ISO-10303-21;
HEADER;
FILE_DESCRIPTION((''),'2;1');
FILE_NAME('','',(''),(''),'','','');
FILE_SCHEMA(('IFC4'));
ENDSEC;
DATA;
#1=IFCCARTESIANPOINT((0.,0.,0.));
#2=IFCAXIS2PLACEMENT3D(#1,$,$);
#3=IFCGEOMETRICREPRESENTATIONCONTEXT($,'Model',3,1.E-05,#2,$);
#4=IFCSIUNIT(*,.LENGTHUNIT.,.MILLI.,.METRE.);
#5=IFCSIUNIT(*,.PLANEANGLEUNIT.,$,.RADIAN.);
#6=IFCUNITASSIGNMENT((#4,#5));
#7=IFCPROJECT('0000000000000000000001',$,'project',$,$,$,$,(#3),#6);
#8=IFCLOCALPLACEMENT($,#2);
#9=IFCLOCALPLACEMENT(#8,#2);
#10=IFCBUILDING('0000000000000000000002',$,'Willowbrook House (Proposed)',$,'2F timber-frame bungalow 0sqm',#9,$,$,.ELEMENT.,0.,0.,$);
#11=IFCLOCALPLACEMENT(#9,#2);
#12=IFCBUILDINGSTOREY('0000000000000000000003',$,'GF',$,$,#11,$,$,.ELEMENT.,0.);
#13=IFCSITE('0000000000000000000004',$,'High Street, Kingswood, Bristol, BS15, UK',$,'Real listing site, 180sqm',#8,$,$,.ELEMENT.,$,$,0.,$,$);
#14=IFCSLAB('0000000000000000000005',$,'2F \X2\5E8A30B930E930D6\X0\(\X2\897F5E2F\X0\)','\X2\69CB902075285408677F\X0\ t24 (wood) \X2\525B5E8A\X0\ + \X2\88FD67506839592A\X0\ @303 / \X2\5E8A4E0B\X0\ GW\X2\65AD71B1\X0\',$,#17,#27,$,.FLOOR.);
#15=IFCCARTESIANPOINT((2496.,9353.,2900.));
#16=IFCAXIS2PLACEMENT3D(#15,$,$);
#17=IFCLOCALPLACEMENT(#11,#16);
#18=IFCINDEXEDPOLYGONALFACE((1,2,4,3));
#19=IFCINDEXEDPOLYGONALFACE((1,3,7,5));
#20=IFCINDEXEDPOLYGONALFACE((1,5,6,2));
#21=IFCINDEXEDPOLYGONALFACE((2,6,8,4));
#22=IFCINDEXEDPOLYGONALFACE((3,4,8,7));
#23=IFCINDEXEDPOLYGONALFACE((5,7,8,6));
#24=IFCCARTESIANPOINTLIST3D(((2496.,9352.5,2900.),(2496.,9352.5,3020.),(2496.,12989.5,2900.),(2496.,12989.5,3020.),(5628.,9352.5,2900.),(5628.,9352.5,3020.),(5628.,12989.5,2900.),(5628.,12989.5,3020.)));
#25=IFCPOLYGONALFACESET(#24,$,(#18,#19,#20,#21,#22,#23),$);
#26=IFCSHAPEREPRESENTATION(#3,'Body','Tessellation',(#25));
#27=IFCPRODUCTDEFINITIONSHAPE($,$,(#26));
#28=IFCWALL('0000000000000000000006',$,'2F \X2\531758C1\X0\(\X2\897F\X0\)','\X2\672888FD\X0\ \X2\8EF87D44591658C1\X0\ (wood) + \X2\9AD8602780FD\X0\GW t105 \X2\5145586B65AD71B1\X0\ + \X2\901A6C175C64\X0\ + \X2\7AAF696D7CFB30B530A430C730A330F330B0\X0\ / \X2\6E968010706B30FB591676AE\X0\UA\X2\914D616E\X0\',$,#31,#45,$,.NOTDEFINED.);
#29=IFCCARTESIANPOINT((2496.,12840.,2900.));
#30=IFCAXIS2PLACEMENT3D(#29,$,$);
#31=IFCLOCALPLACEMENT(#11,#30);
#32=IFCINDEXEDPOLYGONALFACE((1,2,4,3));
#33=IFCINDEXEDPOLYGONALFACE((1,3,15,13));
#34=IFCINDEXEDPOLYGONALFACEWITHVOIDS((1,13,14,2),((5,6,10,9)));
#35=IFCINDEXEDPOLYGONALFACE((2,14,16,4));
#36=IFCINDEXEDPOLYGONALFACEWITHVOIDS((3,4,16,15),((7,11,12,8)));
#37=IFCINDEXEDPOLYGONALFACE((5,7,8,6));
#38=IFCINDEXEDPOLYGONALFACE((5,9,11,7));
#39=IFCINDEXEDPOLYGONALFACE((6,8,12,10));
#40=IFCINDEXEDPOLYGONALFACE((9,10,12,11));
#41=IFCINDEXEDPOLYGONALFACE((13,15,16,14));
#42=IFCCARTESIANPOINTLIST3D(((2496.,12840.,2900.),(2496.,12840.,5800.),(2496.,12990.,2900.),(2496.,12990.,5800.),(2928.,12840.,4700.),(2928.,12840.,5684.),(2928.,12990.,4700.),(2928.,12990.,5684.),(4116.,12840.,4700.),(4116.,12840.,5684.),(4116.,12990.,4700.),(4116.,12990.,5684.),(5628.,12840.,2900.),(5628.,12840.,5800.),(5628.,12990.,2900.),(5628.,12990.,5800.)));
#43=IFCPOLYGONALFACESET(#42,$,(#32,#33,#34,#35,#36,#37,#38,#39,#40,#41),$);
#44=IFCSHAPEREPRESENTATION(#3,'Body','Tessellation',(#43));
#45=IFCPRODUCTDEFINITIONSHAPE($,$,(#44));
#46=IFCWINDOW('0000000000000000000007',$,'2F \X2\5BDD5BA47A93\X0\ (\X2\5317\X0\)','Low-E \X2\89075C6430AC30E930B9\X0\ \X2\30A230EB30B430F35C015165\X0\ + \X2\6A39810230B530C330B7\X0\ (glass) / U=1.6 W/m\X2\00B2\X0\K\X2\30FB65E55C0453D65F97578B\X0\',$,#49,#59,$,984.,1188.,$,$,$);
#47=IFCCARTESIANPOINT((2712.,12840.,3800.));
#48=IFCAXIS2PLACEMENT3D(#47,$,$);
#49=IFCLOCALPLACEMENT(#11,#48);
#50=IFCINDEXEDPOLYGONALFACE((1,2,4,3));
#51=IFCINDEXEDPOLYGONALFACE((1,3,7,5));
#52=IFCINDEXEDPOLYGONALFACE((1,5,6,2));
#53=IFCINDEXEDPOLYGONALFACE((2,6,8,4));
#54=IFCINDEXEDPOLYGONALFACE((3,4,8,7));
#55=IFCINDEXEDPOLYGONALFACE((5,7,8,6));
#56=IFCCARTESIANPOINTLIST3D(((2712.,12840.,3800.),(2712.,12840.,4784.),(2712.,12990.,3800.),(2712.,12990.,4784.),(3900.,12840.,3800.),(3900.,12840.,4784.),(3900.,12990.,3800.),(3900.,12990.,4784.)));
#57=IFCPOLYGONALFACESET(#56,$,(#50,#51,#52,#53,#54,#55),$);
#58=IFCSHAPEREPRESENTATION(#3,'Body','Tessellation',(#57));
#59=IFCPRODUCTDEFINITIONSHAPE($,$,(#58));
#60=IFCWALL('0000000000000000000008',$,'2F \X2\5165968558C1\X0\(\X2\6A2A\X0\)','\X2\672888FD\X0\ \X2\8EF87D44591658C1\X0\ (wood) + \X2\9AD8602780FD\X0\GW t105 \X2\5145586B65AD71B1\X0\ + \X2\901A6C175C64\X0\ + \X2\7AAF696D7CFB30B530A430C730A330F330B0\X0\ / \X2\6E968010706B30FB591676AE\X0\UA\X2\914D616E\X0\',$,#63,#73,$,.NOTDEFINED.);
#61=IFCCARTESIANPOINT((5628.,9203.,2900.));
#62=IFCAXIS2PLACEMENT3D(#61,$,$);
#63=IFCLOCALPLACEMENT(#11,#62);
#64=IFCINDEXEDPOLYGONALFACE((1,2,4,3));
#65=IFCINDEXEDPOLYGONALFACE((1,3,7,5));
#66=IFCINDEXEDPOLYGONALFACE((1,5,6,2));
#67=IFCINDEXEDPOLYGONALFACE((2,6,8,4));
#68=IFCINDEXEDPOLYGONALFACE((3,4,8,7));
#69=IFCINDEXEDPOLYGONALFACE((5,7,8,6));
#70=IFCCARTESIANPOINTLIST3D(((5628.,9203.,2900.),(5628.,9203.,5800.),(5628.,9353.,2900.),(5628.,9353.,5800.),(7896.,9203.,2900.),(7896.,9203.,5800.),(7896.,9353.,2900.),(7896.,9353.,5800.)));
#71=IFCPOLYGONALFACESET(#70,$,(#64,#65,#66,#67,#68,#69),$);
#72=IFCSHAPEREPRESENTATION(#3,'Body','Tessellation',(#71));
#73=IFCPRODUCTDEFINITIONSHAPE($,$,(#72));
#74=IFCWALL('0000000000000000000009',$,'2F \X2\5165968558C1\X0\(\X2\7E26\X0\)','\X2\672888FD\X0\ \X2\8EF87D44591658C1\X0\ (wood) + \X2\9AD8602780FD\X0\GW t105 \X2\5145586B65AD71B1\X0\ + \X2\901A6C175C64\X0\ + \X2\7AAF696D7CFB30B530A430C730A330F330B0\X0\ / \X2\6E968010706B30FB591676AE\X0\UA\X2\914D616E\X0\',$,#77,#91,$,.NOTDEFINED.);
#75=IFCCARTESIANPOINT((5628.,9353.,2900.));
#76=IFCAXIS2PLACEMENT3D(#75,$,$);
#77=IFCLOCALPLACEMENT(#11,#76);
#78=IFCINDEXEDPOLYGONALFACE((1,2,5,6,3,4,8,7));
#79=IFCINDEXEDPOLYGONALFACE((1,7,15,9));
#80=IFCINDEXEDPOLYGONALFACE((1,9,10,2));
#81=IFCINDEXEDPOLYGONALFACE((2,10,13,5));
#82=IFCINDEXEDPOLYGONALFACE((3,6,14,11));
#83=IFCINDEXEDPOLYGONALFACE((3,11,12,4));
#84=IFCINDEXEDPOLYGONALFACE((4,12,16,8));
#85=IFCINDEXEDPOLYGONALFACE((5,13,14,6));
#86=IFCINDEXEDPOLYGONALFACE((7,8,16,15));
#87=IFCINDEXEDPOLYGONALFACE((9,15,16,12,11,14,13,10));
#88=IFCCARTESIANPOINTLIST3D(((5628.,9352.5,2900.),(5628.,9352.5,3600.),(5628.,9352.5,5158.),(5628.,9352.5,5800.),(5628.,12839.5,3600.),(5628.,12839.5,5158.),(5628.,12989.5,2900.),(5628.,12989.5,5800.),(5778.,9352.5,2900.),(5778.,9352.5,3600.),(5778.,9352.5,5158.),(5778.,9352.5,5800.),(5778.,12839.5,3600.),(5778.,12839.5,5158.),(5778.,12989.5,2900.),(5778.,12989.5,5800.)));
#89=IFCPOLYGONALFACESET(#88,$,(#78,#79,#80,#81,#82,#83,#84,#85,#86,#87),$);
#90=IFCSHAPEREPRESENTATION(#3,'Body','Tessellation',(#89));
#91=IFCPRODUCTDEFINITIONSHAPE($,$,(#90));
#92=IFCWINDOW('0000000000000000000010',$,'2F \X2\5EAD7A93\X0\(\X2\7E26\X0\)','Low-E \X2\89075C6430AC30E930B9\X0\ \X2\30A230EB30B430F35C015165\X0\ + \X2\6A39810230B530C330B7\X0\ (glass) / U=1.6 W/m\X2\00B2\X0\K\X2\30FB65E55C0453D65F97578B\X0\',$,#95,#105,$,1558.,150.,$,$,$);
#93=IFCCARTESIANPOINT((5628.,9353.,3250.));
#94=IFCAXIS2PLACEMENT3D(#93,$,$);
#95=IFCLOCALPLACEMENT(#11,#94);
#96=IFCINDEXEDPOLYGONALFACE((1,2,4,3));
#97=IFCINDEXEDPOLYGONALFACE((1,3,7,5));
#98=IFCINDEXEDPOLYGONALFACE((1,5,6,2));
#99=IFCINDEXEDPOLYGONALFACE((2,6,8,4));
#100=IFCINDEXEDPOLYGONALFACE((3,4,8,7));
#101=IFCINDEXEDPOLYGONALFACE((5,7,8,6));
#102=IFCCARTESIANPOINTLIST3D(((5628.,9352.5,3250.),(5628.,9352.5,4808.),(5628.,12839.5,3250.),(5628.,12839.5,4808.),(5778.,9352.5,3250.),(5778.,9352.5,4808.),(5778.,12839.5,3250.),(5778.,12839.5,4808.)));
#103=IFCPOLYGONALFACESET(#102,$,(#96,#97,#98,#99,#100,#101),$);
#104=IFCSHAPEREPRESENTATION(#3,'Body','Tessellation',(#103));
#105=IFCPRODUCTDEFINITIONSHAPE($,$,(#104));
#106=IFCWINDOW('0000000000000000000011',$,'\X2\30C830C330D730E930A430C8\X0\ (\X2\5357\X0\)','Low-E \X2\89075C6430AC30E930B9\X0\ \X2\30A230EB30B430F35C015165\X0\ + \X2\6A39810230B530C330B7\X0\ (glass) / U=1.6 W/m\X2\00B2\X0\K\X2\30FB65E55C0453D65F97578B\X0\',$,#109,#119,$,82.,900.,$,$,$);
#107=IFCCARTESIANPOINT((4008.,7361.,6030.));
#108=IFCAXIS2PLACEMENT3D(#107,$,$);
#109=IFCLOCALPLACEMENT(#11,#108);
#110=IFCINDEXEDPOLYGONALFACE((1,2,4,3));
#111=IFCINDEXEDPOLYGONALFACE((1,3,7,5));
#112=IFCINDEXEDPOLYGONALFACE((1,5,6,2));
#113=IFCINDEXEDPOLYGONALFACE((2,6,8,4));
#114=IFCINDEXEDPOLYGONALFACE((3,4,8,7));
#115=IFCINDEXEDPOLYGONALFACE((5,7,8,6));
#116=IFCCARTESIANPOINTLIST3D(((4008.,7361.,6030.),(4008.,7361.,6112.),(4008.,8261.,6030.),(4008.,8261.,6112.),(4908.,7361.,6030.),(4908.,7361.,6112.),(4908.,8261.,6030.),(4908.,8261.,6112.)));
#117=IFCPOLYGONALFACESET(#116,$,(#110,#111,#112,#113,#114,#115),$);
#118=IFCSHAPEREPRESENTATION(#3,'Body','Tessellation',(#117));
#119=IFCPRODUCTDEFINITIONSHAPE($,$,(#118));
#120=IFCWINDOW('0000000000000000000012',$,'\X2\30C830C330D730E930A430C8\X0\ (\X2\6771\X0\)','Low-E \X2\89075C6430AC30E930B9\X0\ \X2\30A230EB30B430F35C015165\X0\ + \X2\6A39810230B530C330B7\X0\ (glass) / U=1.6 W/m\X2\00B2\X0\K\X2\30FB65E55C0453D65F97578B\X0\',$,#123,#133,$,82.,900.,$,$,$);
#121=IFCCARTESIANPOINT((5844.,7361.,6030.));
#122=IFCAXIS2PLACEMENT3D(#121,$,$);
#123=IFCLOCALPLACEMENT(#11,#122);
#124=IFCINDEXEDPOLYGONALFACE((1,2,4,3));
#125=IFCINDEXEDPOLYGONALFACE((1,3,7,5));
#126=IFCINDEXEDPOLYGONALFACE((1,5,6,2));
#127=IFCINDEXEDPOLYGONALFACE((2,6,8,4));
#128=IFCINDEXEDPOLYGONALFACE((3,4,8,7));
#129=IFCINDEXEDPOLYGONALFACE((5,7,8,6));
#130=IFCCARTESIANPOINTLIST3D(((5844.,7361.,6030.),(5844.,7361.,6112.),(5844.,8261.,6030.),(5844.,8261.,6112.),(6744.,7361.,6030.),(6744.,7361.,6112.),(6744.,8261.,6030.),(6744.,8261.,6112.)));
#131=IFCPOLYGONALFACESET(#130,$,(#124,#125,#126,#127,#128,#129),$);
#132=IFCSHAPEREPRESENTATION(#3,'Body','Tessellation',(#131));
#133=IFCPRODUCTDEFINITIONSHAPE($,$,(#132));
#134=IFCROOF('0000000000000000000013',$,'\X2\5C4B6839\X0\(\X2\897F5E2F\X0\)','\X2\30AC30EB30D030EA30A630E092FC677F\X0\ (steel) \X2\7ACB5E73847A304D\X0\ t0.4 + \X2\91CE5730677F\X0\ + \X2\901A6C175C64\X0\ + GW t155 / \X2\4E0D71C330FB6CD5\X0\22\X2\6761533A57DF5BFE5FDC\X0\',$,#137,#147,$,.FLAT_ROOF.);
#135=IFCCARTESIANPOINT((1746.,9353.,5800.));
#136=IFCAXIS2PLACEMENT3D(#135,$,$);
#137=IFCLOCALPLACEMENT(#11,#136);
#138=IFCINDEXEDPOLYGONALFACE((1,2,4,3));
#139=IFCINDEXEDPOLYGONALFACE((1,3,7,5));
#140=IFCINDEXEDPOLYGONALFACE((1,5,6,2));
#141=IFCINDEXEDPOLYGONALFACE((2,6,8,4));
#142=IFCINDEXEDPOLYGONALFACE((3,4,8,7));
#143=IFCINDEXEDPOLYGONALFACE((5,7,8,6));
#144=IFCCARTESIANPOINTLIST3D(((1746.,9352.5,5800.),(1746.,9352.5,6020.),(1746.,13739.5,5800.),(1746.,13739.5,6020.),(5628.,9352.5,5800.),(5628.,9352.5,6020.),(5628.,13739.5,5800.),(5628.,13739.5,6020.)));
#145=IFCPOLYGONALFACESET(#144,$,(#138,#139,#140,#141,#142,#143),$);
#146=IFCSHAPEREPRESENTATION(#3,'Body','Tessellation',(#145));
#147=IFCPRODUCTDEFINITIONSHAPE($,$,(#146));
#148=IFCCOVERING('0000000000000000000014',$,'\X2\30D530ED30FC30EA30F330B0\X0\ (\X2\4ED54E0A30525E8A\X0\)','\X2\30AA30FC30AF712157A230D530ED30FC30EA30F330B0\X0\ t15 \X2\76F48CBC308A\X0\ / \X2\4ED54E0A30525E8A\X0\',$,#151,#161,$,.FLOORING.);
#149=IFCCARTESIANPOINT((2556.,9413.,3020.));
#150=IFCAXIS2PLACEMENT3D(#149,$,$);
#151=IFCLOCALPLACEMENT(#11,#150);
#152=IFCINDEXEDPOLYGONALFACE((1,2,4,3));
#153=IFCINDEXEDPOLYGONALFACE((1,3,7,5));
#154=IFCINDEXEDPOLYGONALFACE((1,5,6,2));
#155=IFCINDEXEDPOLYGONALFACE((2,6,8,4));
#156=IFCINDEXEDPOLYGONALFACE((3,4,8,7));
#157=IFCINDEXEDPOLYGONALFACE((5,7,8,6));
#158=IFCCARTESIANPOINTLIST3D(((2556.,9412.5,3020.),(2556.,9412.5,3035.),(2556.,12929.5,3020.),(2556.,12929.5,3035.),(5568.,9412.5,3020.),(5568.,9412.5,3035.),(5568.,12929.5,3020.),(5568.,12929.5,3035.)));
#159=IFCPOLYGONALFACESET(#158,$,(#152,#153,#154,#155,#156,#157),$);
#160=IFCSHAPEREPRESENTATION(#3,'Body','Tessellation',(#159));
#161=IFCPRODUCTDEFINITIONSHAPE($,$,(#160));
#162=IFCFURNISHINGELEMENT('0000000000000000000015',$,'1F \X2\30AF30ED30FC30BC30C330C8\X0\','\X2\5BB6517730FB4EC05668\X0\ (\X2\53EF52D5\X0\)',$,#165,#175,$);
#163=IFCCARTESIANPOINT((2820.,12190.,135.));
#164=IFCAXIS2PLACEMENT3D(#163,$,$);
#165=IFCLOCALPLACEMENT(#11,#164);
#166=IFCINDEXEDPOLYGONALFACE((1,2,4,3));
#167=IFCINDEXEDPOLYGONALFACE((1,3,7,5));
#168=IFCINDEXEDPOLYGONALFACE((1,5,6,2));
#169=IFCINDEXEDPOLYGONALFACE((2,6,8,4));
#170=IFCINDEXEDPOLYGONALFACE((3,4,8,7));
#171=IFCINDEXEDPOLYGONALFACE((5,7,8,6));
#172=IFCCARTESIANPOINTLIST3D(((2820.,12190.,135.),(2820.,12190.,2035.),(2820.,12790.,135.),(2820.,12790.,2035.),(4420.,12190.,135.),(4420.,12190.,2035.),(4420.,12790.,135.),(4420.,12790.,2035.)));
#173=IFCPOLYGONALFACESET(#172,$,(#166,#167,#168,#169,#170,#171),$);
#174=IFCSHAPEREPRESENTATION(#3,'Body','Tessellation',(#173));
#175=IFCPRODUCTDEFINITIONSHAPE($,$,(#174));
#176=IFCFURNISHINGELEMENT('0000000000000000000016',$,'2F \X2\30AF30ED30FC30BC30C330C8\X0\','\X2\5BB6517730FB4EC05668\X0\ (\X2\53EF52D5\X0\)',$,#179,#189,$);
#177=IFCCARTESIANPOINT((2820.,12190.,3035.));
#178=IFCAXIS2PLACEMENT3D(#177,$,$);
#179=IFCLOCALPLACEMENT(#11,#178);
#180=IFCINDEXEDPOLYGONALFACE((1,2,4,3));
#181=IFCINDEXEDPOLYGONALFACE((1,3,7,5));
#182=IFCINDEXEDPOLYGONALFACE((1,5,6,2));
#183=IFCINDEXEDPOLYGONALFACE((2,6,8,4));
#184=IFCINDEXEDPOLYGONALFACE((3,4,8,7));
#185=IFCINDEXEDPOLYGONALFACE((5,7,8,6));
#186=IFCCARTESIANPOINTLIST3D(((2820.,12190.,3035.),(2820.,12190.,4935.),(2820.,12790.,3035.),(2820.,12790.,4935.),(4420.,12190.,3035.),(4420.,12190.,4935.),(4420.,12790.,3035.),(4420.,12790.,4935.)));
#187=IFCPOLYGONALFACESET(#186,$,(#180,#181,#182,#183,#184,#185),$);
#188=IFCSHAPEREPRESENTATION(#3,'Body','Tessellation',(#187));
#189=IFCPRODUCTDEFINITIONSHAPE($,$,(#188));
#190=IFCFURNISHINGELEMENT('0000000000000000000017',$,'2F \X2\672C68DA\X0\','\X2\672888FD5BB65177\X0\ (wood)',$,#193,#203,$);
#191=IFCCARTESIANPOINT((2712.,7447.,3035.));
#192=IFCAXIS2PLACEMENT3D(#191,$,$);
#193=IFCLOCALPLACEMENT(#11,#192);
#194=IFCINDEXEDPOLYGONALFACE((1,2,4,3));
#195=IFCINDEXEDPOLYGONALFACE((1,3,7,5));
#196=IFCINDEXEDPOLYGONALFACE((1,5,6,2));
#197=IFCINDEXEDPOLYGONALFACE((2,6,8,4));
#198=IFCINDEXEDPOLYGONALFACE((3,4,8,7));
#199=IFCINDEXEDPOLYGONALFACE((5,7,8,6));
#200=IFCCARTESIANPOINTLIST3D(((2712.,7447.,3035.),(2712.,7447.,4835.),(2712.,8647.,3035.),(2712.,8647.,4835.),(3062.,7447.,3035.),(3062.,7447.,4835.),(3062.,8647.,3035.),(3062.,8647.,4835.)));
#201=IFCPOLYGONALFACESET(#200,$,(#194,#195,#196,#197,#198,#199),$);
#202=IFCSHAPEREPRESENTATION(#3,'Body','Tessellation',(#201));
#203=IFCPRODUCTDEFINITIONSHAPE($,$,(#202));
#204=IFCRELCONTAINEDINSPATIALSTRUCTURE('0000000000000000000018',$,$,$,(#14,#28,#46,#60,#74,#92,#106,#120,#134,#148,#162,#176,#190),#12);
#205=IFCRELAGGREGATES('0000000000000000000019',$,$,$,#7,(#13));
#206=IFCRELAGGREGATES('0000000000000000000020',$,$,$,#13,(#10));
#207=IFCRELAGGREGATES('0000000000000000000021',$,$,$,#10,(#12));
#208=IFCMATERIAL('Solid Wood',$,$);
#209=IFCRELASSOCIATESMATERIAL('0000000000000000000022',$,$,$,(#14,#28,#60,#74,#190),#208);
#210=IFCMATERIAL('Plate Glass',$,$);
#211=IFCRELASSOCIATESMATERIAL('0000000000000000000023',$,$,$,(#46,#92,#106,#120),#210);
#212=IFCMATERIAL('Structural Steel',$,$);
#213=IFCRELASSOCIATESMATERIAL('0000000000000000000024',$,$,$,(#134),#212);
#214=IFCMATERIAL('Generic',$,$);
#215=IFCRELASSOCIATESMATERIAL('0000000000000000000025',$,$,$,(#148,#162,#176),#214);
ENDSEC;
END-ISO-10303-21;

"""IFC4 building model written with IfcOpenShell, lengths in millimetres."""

from ifc_helpers import new_model, si_unit, frame, frame_2d, origin, place, context, project, spatial, rectangle, extrude, material, element, fill, save


model = new_model("IFC4")

# Units and contexts
model_context = context("Model", 3, precision=1e-05, world=origin())
ifc_project = project(units=[si_unit("LENGTHUNIT", "METRE", prefix="MILLI"), si_unit("PLANEANGLEUNIT", "RADIAN")], contexts=[model_context])

# Site, building, storey
site_placement = place(None, origin())
site = spatial("IfcSite", under=ifc_project, at=site_placement, Name="High Street, Kingswood, Bristol, BS15, UK", ObjectType="Real listing site, 180sqm", CompositionType="ELEMENT", RefElevation=0.0)
building_placement = place(site_placement, origin())
building = spatial("IfcBuilding", under=site, at=building_placement, Name="Willowbrook House (Proposed)", ObjectType="2F timber-frame bungalow 0sqm", CompositionType="ELEMENT", ElevationOfRefHeight=0.0, ElevationOfTerrain=0.0)
storey_placement = place(building_placement, origin())
storey = spatial("IfcBuildingStorey", under=building, at=storey_placement, Name="GF", CompositionType="ELEMENT", Elevation=0.0)

# Slab
ifc_material_1 = material(Name="Solid Wood")
slab_placement = place(storey_placement, frame((2496.0, 9353.0, 2900.0)))
element("IfcSlab", 1, at=slab_placement, inside=storey, material=ifc_material_1, Name="2F 床スラブ(西帯)", Description="構造用合板 t24 (wood) 剛床 + 製材根太 @303 / 床下 GW断熱", PredefinedType="FLOOR", context=model_context, shape_type="SweptSolid", body=[
    extrude(rectangle(XDim=3132.0, YDim=3637.0, at=frame_2d((1566.0, 1818.0))), frame((2496.0, 9353.0, 2900.0)), (0.0, 0.0, 1.0), 120.0),
])

# Wall, opening, window
wall_1_placement = place(storey_placement, frame((2496.0, 12840.0, 2900.0)))
wall_1 = element("IfcWall", 2, at=wall_1_placement, inside=storey, material=ifc_material_1, Name="2F 北壁(西)", Description="木製 軸組外壁 (wood) + 高性能GW t105 充填断熱 + 通気層 + 窯業系サイディング / 準耐火・外皮UA配慮", PredefinedType="NOTDEFINED", context=model_context, shape_type="SweptSolid", body=[
    extrude(rectangle(XDim=3132.0, YDim=150.0, at=frame_2d((1566.0, 75.0))), frame((2496.0, 12840.0, 2900.0)), (0.0, 0.0, 1.0), 2900.0),
])
opening_1_placement = place(storey_placement, frame((2712.0, 12840.0, 3800.0)))
opening_1 = element("IfcOpeningElement", 3, at=opening_1_placement, cuts=wall_1, PredefinedType="NOTDEFINED", context=model_context, shape_type="SweptSolid", body=[
    extrude(rectangle(XDim=1188.0, YDim=150.0, at=frame_2d((594.0, 75.0))), frame((2712.0, 12840.0, 3800.0)), (0.0, 0.0, 1.0), 984.0),
])
ifc_material_2 = material(Name="Plate Glass")
window_1_placement = place(storey_placement, frame((2712.0, 12840.0, 3800.0)))
window_1 = element("IfcWindow", 4, at=window_1_placement, inside=storey, material=ifc_material_2, Name="2F 寝室窓 (北)", Description="Low-E 複層ガラス アルゴン封入 + 樹脂サッシ (glass) / U=1.6 W/m²K・日射取得型", OverallHeight=984.0, OverallWidth=1188.0, context=model_context, shape_type="SweptSolid", body=[
    extrude(rectangle(XDim=1188.0, YDim=150.0, at=frame_2d((594.0, 75.0))), frame((2712.0, 12840.0, 3800.0)), (0.0, 0.0, 1.0), 984.0),
])
fill(opening_1, window_1)

# Wall
wall_2_placement = place(storey_placement, frame((5628.0, 9203.0, 2900.0)))
element("IfcWall", 5, at=wall_2_placement, inside=storey, material=ifc_material_1, Name="2F 入隅壁(横)", Description="木製 軸組外壁 (wood) + 高性能GW t105 充填断熱 + 通気層 + 窯業系サイディング / 準耐火・外皮UA配慮", PredefinedType="NOTDEFINED", context=model_context, shape_type="SweptSolid", body=[
    extrude(rectangle(XDim=2268.0, YDim=150.0, at=frame_2d((1134.0, 75.0))), frame((5628.0, 9203.0, 2900.0)), (0.0, 0.0, 1.0), 2900.0),
])

# Wall, opening, window
wall_3_placement = place(storey_placement, frame((5628.0, 9353.0, 2900.0)))
wall_3 = element("IfcWall", 6, at=wall_3_placement, inside=storey, material=ifc_material_1, Name="2F 入隅壁(縦)", Description="木製 軸組外壁 (wood) + 高性能GW t105 充填断熱 + 通気層 + 窯業系サイディング / 準耐火・外皮UA配慮", PredefinedType="NOTDEFINED", context=model_context, shape_type="SweptSolid", body=[
    extrude(rectangle(XDim=150.0, YDim=3637.0, at=frame_2d((75.0, 1818.0))), frame((5628.0, 9353.0, 2900.0)), (0.0, 0.0, 1.0), 2900.0),
])
opening_2_placement = place(storey_placement, frame((5628.0, 9353.0, 3250.0)))
opening_2 = element("IfcOpeningElement", 7, at=opening_2_placement, cuts=wall_3, PredefinedType="NOTDEFINED", context=model_context, shape_type="SweptSolid", body=[
    extrude(rectangle(XDim=150.0, YDim=3487.0, at=frame_2d((75.0, 1743.0))), frame((5628.0, 9353.0, 3250.0)), (0.0, 0.0, 1.0), 1558.0),
])
window_2_placement = place(storey_placement, frame((5628.0, 9353.0, 3250.0)))
window_2 = element("IfcWindow", 8, at=window_2_placement, inside=storey, material=ifc_material_2, Name="2F 庭窓(縦)", Description="Low-E 複層ガラス アルゴン封入 + 樹脂サッシ (glass) / U=1.6 W/m²K・日射取得型", OverallHeight=1558.0, OverallWidth=150.0, context=model_context, shape_type="SweptSolid", body=[
    extrude(rectangle(XDim=150.0, YDim=3487.0, at=frame_2d((75.0, 1743.0))), frame((5628.0, 9353.0, 3250.0)), (0.0, 0.0, 1.0), 1558.0),
])
fill(opening_2, window_2)

# Windows
window_3_placement = place(storey_placement, frame((4008.0, 7361.0, 6030.0)))
element("IfcWindow", 9, at=window_3_placement, inside=storey, material=ifc_material_2, Name="トップライト (南)", Description="Low-E 複層ガラス アルゴン封入 + 樹脂サッシ (glass) / U=1.6 W/m²K・日射取得型", OverallHeight=82.0, OverallWidth=900.0, context=model_context, shape_type="SweptSolid", body=[
    extrude(rectangle(XDim=900.0, YDim=900.0, at=frame_2d((450.0, 450.0))), frame((4008.0, 7361.0, 6030.0)), (0.0, 0.0, 1.0), 82.0),
])
window_4_placement = place(storey_placement, frame((5844.0, 7361.0, 6030.0)))
element("IfcWindow", 10, at=window_4_placement, inside=storey, material=ifc_material_2, Name="トップライト (東)", Description="Low-E 複層ガラス アルゴン封入 + 樹脂サッシ (glass) / U=1.6 W/m²K・日射取得型", OverallHeight=82.0, OverallWidth=900.0, context=model_context, shape_type="SweptSolid", body=[
    extrude(rectangle(XDim=900.0, YDim=900.0, at=frame_2d((450.0, 450.0))), frame((5844.0, 7361.0, 6030.0)), (0.0, 0.0, 1.0), 82.0),
])

# Roof
ifc_material_3 = material(Name="Structural Steel")
for number, where, name in (
    (11, (1746.0, 9353.0, 5800.0), "屋根(西帯)"),
):
    element("IfcRoof", number, at=place(storey_placement, frame(where)), inside=storey, material=ifc_material_3, Name=name, Description="ガルバリウム鋼板 (steel) 立平葺き t0.4 + 野地板 + 通気層 + GW t155 / 不燃・法22条区域対応", PredefinedType="FLAT_ROOF", context=model_context, shape_type="SweptSolid", body=[
        extrude(rectangle(XDim=3882.0, YDim=4387.0, at=frame_2d((1941.0, 2193.0))), frame((1746.0, 9353.0, 5800.0)), (0.0, 0.0, 1.0), 220.0),
    ])

# Covering
ifc_material_4 = material(Name="Generic")
covering_placement = place(storey_placement, frame((2556.0, 9413.0, 3020.0)))
element("IfcCovering", 12, at=covering_placement, inside=storey, material=ifc_material_4, Name="フローリング (仕上げ床)", Description="オーク無垢フローリング t15 直貼り / 仕上げ床", PredefinedType="FLOORING", context=model_context, shape_type="SweptSolid", body=[
    extrude(rectangle(XDim=3012.0, YDim=3517.0, at=frame_2d((1506.0, 1758.0))), frame((2556.0, 9413.0, 3020.0)), (0.0, 0.0, 1.0), 15.0),
])

# Furnishing elements
furnishing_1_placement = place(storey_placement, frame((2820.0, 12190.0, 135.0)))
element("IfcFurnishingElement", 13, at=furnishing_1_placement, inside=storey, material=ifc_material_4, Name="1F クローゼット", Description="家具・什器 (可動)", context=model_context, shape_type="SweptSolid", body=[
    extrude(rectangle(XDim=1600.0, YDim=600.0, at=frame_2d((800.0, 300.0))), frame((2820.0, 12190.0, 135.0)), (0.0, 0.0, 1.0), 1900.0),
])
furnishing_2_placement = place(storey_placement, frame((2820.0, 12190.0, 3035.0)))
element("IfcFurnishingElement", 14, at=furnishing_2_placement, inside=storey, material=ifc_material_4, Name="2F クローゼット", Description="家具・什器 (可動)", context=model_context, shape_type="SweptSolid", body=[
    extrude(rectangle(XDim=1600.0, YDim=600.0, at=frame_2d((800.0, 300.0))), frame((2820.0, 12190.0, 3035.0)), (0.0, 0.0, 1.0), 1900.0),
])
furnishing_3_placement = place(storey_placement, frame((2712.0, 7447.0, 3035.0)))
element("IfcFurnishingElement", 15, at=furnishing_3_placement, inside=storey, material=ifc_material_1, Name="2F 本棚", Description="木製家具 (wood)", context=model_context, shape_type="SweptSolid", body=[
    extrude(rectangle(XDim=350.0, YDim=1200.0, at=frame_2d((175.0, 600.0))), frame((2712.0, 7447.0, 3035.0)), (0.0, 0.0, 1.0), 1800.0),
])

save(model, "model.ifc")
